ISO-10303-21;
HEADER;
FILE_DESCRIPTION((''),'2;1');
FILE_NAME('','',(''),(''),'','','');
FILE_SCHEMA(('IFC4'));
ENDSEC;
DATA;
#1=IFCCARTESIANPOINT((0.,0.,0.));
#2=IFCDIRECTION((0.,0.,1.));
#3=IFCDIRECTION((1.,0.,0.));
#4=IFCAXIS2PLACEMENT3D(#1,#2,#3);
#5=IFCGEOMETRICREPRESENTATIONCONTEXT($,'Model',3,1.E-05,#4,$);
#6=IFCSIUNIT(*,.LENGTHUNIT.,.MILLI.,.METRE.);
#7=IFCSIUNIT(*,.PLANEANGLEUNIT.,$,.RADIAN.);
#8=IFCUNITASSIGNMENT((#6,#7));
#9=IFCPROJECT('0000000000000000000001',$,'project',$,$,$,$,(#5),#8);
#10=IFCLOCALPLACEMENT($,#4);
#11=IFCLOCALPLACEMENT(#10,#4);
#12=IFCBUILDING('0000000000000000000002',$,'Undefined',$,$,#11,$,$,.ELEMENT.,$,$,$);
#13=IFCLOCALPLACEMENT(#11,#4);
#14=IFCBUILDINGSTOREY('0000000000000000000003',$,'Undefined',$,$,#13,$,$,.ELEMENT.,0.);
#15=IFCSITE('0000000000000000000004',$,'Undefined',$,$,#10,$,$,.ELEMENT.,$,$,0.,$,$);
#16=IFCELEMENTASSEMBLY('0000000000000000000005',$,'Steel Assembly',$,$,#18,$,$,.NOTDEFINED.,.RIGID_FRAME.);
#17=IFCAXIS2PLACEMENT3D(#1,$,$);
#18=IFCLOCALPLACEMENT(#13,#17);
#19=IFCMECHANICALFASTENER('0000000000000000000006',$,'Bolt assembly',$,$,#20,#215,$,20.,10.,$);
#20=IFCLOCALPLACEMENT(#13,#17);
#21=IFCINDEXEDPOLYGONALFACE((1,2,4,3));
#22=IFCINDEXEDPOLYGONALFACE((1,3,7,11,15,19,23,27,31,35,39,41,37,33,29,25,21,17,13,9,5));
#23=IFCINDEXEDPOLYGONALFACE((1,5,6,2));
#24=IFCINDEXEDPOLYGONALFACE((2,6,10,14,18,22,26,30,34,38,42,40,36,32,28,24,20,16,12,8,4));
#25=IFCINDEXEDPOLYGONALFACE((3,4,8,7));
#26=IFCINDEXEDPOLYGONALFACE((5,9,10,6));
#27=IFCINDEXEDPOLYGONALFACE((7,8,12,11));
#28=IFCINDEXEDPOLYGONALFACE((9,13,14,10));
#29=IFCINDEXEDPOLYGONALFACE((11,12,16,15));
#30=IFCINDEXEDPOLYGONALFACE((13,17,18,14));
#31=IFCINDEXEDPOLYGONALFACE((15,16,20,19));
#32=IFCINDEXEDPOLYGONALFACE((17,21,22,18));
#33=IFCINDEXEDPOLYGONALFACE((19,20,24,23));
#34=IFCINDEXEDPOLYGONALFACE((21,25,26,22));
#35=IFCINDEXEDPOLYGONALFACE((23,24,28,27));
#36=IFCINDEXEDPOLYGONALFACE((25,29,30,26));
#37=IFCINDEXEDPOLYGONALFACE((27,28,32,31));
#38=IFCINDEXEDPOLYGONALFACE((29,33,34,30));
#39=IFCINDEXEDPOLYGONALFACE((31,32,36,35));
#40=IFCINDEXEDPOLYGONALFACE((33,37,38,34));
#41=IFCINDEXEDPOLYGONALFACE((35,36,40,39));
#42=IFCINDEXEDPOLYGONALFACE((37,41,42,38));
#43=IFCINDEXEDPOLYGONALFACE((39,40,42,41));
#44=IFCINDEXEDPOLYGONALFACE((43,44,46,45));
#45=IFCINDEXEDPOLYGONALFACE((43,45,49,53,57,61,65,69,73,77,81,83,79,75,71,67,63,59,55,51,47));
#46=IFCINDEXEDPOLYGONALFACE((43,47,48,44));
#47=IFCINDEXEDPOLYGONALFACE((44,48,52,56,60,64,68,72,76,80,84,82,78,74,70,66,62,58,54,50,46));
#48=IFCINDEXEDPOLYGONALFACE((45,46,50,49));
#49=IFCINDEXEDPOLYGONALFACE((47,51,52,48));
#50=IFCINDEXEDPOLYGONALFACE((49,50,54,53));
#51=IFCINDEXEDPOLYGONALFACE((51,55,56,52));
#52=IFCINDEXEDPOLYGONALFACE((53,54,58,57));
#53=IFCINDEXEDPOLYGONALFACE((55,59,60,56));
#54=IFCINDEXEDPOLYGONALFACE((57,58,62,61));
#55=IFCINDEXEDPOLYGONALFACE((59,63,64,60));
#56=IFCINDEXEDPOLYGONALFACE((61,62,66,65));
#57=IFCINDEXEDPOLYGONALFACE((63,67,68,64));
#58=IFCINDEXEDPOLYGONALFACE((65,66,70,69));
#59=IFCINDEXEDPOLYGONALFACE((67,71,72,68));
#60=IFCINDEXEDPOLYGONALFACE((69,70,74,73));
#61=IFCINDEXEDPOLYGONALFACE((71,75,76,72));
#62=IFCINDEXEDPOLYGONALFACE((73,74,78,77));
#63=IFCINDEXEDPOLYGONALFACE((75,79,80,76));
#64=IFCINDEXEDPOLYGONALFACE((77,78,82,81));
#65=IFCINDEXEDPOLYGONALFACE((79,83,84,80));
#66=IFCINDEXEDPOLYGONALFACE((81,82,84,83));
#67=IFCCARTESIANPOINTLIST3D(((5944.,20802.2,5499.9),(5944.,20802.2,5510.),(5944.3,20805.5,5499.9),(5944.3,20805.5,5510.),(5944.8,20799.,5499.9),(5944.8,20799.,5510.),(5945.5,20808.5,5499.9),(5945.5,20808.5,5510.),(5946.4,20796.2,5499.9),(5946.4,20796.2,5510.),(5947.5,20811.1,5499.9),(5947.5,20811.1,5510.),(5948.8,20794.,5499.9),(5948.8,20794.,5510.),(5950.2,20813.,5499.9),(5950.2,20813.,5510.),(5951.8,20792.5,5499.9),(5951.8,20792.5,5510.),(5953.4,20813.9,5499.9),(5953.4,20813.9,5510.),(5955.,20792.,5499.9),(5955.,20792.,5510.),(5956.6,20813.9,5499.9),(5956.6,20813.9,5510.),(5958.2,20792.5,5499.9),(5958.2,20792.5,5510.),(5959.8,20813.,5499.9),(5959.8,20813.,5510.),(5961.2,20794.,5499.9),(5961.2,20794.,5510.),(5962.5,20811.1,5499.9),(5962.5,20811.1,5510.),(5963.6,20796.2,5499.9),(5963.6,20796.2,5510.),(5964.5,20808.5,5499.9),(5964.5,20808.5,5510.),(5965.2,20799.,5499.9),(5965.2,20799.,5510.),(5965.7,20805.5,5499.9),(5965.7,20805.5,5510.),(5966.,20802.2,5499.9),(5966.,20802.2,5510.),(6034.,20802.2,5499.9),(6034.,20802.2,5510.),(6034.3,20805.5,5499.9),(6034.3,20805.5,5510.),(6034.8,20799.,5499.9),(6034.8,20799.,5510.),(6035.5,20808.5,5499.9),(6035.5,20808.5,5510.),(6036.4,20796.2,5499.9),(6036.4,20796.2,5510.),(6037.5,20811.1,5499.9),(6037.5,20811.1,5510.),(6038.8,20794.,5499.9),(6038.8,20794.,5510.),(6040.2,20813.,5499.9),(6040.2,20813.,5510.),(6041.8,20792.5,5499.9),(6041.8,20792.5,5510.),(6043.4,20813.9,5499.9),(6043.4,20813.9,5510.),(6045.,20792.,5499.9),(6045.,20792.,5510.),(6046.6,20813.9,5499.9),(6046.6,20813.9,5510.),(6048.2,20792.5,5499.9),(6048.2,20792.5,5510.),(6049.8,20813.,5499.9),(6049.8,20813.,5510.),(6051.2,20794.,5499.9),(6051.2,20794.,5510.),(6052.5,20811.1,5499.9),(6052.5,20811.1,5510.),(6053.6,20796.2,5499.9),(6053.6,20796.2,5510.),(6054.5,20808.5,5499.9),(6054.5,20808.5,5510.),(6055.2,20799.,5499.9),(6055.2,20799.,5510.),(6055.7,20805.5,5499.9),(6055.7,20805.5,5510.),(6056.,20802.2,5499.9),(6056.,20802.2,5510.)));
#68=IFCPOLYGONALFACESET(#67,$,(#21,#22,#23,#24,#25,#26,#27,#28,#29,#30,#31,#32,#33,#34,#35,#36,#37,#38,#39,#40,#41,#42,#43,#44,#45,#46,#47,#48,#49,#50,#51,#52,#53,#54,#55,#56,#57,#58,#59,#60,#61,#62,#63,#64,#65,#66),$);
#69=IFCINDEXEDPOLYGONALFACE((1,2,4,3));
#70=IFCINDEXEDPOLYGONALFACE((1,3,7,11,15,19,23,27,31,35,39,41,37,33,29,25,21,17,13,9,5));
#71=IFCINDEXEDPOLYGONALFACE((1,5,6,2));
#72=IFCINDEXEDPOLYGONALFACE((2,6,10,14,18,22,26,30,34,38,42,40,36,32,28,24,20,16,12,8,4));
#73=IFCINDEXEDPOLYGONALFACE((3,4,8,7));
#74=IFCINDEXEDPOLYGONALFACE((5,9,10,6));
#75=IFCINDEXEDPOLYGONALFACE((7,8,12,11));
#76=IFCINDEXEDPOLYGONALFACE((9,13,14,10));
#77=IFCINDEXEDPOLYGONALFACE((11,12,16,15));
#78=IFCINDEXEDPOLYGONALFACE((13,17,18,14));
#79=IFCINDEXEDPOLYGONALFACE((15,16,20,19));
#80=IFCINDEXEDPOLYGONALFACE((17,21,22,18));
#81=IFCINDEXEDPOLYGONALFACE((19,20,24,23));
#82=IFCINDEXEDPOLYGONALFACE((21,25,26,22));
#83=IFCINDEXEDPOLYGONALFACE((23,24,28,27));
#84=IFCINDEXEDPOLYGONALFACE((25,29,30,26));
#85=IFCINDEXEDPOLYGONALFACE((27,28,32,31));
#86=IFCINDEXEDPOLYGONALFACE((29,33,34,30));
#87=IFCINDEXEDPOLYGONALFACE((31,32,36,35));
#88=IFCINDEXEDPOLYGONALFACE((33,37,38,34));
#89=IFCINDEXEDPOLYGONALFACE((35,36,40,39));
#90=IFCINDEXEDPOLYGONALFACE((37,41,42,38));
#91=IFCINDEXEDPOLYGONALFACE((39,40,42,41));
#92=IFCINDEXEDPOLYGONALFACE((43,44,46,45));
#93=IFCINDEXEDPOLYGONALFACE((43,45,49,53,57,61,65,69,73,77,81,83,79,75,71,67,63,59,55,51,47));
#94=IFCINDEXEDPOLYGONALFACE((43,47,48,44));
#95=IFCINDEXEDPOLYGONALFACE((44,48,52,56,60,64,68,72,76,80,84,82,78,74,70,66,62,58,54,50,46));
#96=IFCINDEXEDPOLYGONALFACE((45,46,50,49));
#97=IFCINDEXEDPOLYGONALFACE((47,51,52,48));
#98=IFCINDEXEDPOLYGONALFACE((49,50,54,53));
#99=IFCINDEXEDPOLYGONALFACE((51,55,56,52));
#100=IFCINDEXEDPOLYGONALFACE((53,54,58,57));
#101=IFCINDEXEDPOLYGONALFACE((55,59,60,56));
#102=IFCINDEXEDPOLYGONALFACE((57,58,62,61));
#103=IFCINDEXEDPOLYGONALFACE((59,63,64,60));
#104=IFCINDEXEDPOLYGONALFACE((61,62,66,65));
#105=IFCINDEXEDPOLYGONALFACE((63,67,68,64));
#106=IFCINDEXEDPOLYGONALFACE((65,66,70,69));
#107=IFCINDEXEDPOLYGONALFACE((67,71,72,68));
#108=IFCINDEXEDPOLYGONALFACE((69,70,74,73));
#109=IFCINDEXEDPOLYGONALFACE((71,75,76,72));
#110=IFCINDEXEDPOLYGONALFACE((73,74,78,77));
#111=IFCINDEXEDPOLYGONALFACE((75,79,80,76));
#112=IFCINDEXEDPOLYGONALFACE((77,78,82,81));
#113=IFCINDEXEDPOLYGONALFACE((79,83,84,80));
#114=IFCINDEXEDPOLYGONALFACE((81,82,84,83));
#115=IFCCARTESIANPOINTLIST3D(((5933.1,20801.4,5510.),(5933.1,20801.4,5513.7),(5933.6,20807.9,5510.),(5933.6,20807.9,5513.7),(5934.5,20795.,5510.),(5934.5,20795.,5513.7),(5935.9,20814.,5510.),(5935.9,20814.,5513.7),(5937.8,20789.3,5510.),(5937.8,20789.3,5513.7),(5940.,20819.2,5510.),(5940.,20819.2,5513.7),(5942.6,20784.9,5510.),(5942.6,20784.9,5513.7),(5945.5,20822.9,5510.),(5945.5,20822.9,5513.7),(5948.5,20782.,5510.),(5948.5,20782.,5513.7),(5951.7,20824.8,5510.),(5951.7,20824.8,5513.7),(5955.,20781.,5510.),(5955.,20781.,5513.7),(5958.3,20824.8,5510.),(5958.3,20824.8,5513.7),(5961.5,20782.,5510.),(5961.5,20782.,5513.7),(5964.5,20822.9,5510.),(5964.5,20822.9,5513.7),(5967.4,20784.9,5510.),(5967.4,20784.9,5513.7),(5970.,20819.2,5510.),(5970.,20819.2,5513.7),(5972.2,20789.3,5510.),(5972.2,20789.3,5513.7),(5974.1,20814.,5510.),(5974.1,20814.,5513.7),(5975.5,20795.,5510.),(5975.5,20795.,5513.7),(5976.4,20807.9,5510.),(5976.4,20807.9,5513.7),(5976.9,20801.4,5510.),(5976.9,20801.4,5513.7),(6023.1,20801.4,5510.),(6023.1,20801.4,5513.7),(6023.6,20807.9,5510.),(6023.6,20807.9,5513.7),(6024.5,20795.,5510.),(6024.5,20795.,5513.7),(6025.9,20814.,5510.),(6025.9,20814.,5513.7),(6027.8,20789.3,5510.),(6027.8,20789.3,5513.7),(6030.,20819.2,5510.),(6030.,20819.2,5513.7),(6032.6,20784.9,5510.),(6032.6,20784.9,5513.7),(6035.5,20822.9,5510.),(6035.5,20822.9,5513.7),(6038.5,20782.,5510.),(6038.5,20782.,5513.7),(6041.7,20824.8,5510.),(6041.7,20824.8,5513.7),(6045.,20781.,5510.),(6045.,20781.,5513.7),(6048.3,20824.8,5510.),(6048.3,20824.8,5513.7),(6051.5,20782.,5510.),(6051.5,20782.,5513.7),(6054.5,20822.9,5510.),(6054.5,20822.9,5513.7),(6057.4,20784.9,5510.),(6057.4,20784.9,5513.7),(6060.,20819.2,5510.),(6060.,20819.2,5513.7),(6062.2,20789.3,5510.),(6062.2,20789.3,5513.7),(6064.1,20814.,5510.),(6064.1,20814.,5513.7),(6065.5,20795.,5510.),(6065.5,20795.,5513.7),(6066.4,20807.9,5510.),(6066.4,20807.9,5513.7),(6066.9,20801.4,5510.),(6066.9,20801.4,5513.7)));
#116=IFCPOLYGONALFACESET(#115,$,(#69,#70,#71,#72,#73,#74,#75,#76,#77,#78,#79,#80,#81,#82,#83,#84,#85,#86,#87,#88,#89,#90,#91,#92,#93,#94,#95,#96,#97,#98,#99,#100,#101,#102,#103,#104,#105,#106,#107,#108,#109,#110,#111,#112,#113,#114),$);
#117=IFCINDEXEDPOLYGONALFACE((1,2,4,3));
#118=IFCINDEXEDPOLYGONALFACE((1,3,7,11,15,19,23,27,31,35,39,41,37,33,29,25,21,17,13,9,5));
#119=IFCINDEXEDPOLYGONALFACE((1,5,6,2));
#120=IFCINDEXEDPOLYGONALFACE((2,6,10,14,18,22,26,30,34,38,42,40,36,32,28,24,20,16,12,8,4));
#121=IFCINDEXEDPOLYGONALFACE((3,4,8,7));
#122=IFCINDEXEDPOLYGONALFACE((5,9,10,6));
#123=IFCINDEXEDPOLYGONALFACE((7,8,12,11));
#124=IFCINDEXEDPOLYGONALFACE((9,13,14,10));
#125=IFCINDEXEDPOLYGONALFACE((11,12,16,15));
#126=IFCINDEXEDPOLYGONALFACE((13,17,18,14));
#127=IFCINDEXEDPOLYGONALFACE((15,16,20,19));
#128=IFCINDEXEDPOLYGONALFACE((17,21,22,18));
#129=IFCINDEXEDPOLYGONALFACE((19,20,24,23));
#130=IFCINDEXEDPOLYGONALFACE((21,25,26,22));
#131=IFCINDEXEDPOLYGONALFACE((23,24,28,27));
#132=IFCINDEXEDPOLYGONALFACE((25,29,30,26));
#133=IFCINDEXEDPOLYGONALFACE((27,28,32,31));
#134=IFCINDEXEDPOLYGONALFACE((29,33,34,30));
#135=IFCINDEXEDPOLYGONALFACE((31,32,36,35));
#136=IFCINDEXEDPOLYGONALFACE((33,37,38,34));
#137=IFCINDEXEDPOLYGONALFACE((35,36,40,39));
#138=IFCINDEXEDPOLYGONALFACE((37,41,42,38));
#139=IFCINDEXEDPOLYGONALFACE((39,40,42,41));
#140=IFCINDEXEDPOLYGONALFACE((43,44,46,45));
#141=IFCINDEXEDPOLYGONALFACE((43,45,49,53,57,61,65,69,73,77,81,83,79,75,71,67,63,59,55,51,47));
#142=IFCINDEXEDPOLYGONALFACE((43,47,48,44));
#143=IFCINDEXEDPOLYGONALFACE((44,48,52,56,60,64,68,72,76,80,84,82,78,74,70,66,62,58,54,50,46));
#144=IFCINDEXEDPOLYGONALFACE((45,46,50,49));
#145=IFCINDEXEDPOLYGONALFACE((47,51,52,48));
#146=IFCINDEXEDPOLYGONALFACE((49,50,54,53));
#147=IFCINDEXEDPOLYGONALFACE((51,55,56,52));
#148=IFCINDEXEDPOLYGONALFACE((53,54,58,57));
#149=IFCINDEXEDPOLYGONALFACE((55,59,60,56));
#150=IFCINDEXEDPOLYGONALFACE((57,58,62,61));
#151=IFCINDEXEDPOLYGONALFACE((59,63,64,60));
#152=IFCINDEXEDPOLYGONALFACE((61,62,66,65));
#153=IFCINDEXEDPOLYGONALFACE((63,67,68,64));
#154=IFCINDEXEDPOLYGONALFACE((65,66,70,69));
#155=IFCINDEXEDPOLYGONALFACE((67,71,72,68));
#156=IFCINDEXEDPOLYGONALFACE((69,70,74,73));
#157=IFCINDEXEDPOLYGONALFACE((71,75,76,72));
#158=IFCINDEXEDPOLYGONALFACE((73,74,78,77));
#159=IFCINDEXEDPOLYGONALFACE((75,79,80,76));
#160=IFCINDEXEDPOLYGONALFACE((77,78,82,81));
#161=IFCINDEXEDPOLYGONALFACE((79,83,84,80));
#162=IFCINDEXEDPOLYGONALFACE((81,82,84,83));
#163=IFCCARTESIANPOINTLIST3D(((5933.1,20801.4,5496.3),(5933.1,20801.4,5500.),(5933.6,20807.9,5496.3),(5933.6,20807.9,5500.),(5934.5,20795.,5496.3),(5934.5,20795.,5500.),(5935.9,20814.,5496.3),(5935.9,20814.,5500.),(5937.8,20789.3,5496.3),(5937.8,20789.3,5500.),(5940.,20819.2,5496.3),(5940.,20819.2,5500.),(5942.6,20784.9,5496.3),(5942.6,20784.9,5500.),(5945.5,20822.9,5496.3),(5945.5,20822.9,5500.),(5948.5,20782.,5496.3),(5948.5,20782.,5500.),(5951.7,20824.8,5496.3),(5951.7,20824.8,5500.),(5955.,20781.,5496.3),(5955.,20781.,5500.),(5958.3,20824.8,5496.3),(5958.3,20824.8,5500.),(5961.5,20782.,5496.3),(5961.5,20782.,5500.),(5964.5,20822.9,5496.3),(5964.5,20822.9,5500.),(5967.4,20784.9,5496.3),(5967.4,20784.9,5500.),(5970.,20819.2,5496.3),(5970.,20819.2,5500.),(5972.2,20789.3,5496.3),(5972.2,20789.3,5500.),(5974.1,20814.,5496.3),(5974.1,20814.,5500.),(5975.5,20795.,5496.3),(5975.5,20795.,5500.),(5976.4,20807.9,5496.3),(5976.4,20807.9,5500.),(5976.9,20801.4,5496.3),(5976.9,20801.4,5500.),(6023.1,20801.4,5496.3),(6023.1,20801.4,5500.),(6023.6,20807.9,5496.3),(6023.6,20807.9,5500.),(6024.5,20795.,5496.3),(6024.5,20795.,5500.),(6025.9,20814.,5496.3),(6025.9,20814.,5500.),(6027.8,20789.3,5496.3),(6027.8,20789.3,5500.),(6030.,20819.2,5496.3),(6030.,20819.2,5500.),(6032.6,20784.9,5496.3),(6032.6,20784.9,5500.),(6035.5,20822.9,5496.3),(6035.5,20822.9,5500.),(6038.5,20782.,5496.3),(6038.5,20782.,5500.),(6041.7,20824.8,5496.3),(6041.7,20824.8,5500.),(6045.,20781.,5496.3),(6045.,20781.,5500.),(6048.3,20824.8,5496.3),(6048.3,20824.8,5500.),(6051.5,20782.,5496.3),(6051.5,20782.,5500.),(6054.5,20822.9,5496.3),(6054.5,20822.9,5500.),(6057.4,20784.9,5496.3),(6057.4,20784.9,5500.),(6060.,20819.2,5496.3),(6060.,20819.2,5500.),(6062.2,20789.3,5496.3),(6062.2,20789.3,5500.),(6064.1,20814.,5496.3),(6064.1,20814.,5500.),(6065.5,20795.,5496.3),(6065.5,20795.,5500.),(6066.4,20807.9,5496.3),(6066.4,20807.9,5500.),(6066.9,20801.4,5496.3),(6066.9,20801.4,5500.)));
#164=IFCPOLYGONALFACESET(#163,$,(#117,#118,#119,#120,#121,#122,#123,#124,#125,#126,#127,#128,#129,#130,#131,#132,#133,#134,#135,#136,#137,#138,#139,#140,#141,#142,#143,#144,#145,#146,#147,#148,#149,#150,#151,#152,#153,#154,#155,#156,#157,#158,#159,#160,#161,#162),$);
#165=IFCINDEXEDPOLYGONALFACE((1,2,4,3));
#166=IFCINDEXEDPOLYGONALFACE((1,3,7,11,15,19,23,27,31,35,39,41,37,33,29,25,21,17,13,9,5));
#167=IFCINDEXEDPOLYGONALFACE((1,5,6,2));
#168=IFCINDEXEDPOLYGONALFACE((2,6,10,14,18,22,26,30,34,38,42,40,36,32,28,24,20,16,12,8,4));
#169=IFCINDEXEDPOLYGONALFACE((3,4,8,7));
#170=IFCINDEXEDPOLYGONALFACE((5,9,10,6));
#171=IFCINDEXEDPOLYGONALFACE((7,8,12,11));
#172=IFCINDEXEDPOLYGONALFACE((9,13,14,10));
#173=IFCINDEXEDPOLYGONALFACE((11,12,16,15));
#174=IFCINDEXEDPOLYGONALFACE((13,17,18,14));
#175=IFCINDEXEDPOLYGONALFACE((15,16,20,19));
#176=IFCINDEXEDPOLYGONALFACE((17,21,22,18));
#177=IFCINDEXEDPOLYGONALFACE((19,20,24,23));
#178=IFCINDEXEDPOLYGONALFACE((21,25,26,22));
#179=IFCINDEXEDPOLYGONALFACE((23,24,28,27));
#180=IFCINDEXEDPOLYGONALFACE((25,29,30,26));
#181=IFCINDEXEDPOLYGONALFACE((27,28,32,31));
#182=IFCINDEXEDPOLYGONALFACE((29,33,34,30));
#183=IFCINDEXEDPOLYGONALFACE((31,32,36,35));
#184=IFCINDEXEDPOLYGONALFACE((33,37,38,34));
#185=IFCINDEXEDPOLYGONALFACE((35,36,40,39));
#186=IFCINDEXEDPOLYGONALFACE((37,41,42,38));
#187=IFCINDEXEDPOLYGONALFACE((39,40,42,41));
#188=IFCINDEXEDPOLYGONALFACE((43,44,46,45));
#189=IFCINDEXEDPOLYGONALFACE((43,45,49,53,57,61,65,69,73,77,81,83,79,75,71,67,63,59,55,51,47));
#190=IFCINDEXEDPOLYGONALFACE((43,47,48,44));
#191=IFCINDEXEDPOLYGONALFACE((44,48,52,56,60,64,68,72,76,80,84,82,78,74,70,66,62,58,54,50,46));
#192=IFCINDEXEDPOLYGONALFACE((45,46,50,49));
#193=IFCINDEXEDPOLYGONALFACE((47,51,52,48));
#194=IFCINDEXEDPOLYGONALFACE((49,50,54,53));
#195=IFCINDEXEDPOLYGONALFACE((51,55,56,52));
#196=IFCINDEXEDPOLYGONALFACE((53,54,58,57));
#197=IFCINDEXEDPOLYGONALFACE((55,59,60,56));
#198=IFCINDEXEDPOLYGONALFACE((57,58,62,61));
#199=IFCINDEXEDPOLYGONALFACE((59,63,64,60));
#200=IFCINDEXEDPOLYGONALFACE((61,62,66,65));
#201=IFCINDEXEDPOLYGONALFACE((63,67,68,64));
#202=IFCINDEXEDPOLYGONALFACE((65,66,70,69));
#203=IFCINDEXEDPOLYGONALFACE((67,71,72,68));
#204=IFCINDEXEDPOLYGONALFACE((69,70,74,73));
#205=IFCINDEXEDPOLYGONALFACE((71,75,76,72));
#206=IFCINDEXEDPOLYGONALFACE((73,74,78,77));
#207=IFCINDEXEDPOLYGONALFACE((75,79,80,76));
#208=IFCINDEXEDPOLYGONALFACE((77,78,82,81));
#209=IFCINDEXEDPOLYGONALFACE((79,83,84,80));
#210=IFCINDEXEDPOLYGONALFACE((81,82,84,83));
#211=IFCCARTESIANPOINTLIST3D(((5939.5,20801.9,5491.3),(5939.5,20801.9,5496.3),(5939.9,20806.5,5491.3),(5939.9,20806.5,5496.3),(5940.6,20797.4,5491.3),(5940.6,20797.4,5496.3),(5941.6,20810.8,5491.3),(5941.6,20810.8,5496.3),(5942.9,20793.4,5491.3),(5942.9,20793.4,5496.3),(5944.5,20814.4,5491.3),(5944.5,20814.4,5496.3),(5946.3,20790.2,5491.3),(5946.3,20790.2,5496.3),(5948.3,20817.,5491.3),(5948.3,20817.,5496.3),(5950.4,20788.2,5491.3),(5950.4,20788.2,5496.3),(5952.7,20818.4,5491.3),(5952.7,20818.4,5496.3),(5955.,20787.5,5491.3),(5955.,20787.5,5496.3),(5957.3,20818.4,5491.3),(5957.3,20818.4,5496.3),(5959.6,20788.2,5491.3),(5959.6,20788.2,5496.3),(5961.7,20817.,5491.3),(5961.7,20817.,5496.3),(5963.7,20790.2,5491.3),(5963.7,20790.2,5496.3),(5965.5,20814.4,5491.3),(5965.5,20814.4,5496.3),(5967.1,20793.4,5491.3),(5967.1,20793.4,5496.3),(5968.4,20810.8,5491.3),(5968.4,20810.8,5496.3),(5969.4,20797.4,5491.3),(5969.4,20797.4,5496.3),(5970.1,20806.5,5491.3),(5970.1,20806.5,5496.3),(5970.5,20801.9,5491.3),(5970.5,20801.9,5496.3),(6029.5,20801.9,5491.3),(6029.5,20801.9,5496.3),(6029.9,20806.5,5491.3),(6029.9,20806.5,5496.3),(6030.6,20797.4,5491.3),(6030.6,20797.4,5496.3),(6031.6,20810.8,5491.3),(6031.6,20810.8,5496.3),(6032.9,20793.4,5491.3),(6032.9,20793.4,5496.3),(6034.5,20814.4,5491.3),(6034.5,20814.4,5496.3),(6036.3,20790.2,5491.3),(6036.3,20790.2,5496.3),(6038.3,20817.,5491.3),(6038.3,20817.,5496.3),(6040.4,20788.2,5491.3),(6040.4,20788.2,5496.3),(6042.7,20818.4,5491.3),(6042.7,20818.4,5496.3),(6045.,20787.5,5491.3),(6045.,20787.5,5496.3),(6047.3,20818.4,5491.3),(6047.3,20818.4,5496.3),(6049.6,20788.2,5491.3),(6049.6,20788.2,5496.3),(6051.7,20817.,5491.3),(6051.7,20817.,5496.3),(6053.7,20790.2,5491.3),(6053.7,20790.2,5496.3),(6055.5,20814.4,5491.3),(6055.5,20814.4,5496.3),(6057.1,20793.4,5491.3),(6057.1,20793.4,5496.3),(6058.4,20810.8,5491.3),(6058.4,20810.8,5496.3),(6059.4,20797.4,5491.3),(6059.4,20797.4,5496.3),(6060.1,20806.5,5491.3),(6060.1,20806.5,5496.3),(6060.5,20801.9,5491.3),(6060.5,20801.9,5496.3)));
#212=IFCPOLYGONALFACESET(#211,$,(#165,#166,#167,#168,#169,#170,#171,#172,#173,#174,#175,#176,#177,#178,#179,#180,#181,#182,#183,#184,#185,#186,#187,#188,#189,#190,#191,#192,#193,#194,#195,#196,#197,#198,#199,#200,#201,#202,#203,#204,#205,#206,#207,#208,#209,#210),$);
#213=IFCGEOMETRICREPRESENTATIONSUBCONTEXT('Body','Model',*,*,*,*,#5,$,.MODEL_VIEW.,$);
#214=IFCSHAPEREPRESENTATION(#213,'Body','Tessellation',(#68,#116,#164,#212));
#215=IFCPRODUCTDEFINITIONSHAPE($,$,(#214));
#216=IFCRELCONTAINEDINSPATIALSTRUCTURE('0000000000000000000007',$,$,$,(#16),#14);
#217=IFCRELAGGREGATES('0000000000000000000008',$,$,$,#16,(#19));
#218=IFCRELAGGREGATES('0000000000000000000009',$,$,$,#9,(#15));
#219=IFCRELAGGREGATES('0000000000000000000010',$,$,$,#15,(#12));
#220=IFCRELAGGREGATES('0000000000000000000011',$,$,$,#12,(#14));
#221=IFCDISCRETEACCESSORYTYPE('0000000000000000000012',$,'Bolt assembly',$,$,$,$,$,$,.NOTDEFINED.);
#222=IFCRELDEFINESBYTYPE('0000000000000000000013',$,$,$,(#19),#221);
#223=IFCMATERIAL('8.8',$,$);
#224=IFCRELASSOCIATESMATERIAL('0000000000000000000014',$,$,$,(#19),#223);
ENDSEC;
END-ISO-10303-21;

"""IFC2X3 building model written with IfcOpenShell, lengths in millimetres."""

from ifc_helpers import new_model, si_unit, frame, origin_with_axes, origin_2d_with_axis, place, context, subcontext, project, spatial, circle, extrude, source, transform, mapped, material, type_object, element, aggregate, save


model = new_model("IFC2X3")

# Units and contexts
model_context = context("Model", 3, precision=1e-05, world=origin_with_axes())
body_context = subcontext(model_context, "Body", "Model", "MODEL_VIEW")
ifc_project = project(units=[si_unit("LENGTHUNIT", "METRE", prefix="MILLI"), si_unit("PLANEANGLEUNIT", "RADIAN")], contexts=[model_context])

# Site, building, storey
site_placement = place(None, origin_with_axes())
site = spatial("IfcSite", under=ifc_project, at=site_placement, Name="Undefined", CompositionType="ELEMENT", RefElevation=0.0)
building_placement = place(site_placement, origin_with_axes())
building = spatial("IfcBuilding", under=site, at=building_placement, Name="Undefined", CompositionType="ELEMENT")
storey_placement = place(building_placement, origin_with_axes())
storey = spatial("IfcBuildingStorey", under=building, at=storey_placement, Name="Undefined", CompositionType="ELEMENT", Elevation=0.0)

# Element assembly
assembly_1_placement = place(storey_placement, origin_with_axes())
assembly_1 = element("IfcElementAssembly", 1, at=assembly_1_placement, inside=storey, Name="Steel Assembly", AssemblyPlace="NOTDEFINED", PredefinedType="RIGID_FRAME")

# Mechanical fastener
ifc_material_1 = material(Name="8.8")
discrete_accessory_type_1 = type_object("IfcDiscreteAccessoryType", Name="Bolt assembly")
shared_shape = source(origin_with_axes(), body_context, "Body", "SweptSolid", [
    extrude(circle(Radius=11.0, at=origin_2d_with_axis()), frame((0.0, -10.0, 0.0), z_axis=(0.0, 1.0, 0.0), x_axis=(1.0, 0.0, 0.0)), (0.0, 0.0, 1.0), 10.1),
    extrude(circle(Radius=22.0, at=origin_2d_with_axis()), frame((0.0, -13.7, 0.0), z_axis=(0.0, 1.0, 0.0), x_axis=(1.0, 0.0, 0.0)), (0.0, 0.0, 1.0), 3.7),
    extrude(circle(Radius=22.0, at=origin_2d_with_axis()), frame((0.0, 0.0, 0.0), z_axis=(0.0, 1.0, 0.0), x_axis=(1.0, 0.0, 0.0)), (0.0, 0.0, 1.0), 3.7),
    extrude(circle(Radius=15.5, at=origin_2d_with_axis()), frame((0.0, 3.7, 0.0), z_axis=(0.0, 1.0, 0.0), x_axis=(1.0, 0.0, 0.0)), (0.0, 0.0, 1.0), 5.0),
])
mechanical_fastener_1_placement = place(assembly_1_placement, frame((6000.0, 20803.0, 5500.0), z_axis=(1.0, 0.0, 0.0), x_axis=(0.0, -1.0, 0.0)))
mechanical_fastener_1 = element("IfcMechanicalFastener", 2, at=mechanical_fastener_1_placement, type_object=discrete_accessory_type_1, material=ifc_material_1, Name="Bolt assembly", NominalDiameter=20.0, NominalLength=10.0, context=body_context, shape_type="MappedRepresentation", body=[
    mapped(shared_shape, transform((0.0, 0.0, 45.0))),
    mapped(shared_shape, transform((0.0, 0.0, -45.0))),
])
aggregate(assembly_1, [mechanical_fastener_1])

save(model, "model.ifc")
